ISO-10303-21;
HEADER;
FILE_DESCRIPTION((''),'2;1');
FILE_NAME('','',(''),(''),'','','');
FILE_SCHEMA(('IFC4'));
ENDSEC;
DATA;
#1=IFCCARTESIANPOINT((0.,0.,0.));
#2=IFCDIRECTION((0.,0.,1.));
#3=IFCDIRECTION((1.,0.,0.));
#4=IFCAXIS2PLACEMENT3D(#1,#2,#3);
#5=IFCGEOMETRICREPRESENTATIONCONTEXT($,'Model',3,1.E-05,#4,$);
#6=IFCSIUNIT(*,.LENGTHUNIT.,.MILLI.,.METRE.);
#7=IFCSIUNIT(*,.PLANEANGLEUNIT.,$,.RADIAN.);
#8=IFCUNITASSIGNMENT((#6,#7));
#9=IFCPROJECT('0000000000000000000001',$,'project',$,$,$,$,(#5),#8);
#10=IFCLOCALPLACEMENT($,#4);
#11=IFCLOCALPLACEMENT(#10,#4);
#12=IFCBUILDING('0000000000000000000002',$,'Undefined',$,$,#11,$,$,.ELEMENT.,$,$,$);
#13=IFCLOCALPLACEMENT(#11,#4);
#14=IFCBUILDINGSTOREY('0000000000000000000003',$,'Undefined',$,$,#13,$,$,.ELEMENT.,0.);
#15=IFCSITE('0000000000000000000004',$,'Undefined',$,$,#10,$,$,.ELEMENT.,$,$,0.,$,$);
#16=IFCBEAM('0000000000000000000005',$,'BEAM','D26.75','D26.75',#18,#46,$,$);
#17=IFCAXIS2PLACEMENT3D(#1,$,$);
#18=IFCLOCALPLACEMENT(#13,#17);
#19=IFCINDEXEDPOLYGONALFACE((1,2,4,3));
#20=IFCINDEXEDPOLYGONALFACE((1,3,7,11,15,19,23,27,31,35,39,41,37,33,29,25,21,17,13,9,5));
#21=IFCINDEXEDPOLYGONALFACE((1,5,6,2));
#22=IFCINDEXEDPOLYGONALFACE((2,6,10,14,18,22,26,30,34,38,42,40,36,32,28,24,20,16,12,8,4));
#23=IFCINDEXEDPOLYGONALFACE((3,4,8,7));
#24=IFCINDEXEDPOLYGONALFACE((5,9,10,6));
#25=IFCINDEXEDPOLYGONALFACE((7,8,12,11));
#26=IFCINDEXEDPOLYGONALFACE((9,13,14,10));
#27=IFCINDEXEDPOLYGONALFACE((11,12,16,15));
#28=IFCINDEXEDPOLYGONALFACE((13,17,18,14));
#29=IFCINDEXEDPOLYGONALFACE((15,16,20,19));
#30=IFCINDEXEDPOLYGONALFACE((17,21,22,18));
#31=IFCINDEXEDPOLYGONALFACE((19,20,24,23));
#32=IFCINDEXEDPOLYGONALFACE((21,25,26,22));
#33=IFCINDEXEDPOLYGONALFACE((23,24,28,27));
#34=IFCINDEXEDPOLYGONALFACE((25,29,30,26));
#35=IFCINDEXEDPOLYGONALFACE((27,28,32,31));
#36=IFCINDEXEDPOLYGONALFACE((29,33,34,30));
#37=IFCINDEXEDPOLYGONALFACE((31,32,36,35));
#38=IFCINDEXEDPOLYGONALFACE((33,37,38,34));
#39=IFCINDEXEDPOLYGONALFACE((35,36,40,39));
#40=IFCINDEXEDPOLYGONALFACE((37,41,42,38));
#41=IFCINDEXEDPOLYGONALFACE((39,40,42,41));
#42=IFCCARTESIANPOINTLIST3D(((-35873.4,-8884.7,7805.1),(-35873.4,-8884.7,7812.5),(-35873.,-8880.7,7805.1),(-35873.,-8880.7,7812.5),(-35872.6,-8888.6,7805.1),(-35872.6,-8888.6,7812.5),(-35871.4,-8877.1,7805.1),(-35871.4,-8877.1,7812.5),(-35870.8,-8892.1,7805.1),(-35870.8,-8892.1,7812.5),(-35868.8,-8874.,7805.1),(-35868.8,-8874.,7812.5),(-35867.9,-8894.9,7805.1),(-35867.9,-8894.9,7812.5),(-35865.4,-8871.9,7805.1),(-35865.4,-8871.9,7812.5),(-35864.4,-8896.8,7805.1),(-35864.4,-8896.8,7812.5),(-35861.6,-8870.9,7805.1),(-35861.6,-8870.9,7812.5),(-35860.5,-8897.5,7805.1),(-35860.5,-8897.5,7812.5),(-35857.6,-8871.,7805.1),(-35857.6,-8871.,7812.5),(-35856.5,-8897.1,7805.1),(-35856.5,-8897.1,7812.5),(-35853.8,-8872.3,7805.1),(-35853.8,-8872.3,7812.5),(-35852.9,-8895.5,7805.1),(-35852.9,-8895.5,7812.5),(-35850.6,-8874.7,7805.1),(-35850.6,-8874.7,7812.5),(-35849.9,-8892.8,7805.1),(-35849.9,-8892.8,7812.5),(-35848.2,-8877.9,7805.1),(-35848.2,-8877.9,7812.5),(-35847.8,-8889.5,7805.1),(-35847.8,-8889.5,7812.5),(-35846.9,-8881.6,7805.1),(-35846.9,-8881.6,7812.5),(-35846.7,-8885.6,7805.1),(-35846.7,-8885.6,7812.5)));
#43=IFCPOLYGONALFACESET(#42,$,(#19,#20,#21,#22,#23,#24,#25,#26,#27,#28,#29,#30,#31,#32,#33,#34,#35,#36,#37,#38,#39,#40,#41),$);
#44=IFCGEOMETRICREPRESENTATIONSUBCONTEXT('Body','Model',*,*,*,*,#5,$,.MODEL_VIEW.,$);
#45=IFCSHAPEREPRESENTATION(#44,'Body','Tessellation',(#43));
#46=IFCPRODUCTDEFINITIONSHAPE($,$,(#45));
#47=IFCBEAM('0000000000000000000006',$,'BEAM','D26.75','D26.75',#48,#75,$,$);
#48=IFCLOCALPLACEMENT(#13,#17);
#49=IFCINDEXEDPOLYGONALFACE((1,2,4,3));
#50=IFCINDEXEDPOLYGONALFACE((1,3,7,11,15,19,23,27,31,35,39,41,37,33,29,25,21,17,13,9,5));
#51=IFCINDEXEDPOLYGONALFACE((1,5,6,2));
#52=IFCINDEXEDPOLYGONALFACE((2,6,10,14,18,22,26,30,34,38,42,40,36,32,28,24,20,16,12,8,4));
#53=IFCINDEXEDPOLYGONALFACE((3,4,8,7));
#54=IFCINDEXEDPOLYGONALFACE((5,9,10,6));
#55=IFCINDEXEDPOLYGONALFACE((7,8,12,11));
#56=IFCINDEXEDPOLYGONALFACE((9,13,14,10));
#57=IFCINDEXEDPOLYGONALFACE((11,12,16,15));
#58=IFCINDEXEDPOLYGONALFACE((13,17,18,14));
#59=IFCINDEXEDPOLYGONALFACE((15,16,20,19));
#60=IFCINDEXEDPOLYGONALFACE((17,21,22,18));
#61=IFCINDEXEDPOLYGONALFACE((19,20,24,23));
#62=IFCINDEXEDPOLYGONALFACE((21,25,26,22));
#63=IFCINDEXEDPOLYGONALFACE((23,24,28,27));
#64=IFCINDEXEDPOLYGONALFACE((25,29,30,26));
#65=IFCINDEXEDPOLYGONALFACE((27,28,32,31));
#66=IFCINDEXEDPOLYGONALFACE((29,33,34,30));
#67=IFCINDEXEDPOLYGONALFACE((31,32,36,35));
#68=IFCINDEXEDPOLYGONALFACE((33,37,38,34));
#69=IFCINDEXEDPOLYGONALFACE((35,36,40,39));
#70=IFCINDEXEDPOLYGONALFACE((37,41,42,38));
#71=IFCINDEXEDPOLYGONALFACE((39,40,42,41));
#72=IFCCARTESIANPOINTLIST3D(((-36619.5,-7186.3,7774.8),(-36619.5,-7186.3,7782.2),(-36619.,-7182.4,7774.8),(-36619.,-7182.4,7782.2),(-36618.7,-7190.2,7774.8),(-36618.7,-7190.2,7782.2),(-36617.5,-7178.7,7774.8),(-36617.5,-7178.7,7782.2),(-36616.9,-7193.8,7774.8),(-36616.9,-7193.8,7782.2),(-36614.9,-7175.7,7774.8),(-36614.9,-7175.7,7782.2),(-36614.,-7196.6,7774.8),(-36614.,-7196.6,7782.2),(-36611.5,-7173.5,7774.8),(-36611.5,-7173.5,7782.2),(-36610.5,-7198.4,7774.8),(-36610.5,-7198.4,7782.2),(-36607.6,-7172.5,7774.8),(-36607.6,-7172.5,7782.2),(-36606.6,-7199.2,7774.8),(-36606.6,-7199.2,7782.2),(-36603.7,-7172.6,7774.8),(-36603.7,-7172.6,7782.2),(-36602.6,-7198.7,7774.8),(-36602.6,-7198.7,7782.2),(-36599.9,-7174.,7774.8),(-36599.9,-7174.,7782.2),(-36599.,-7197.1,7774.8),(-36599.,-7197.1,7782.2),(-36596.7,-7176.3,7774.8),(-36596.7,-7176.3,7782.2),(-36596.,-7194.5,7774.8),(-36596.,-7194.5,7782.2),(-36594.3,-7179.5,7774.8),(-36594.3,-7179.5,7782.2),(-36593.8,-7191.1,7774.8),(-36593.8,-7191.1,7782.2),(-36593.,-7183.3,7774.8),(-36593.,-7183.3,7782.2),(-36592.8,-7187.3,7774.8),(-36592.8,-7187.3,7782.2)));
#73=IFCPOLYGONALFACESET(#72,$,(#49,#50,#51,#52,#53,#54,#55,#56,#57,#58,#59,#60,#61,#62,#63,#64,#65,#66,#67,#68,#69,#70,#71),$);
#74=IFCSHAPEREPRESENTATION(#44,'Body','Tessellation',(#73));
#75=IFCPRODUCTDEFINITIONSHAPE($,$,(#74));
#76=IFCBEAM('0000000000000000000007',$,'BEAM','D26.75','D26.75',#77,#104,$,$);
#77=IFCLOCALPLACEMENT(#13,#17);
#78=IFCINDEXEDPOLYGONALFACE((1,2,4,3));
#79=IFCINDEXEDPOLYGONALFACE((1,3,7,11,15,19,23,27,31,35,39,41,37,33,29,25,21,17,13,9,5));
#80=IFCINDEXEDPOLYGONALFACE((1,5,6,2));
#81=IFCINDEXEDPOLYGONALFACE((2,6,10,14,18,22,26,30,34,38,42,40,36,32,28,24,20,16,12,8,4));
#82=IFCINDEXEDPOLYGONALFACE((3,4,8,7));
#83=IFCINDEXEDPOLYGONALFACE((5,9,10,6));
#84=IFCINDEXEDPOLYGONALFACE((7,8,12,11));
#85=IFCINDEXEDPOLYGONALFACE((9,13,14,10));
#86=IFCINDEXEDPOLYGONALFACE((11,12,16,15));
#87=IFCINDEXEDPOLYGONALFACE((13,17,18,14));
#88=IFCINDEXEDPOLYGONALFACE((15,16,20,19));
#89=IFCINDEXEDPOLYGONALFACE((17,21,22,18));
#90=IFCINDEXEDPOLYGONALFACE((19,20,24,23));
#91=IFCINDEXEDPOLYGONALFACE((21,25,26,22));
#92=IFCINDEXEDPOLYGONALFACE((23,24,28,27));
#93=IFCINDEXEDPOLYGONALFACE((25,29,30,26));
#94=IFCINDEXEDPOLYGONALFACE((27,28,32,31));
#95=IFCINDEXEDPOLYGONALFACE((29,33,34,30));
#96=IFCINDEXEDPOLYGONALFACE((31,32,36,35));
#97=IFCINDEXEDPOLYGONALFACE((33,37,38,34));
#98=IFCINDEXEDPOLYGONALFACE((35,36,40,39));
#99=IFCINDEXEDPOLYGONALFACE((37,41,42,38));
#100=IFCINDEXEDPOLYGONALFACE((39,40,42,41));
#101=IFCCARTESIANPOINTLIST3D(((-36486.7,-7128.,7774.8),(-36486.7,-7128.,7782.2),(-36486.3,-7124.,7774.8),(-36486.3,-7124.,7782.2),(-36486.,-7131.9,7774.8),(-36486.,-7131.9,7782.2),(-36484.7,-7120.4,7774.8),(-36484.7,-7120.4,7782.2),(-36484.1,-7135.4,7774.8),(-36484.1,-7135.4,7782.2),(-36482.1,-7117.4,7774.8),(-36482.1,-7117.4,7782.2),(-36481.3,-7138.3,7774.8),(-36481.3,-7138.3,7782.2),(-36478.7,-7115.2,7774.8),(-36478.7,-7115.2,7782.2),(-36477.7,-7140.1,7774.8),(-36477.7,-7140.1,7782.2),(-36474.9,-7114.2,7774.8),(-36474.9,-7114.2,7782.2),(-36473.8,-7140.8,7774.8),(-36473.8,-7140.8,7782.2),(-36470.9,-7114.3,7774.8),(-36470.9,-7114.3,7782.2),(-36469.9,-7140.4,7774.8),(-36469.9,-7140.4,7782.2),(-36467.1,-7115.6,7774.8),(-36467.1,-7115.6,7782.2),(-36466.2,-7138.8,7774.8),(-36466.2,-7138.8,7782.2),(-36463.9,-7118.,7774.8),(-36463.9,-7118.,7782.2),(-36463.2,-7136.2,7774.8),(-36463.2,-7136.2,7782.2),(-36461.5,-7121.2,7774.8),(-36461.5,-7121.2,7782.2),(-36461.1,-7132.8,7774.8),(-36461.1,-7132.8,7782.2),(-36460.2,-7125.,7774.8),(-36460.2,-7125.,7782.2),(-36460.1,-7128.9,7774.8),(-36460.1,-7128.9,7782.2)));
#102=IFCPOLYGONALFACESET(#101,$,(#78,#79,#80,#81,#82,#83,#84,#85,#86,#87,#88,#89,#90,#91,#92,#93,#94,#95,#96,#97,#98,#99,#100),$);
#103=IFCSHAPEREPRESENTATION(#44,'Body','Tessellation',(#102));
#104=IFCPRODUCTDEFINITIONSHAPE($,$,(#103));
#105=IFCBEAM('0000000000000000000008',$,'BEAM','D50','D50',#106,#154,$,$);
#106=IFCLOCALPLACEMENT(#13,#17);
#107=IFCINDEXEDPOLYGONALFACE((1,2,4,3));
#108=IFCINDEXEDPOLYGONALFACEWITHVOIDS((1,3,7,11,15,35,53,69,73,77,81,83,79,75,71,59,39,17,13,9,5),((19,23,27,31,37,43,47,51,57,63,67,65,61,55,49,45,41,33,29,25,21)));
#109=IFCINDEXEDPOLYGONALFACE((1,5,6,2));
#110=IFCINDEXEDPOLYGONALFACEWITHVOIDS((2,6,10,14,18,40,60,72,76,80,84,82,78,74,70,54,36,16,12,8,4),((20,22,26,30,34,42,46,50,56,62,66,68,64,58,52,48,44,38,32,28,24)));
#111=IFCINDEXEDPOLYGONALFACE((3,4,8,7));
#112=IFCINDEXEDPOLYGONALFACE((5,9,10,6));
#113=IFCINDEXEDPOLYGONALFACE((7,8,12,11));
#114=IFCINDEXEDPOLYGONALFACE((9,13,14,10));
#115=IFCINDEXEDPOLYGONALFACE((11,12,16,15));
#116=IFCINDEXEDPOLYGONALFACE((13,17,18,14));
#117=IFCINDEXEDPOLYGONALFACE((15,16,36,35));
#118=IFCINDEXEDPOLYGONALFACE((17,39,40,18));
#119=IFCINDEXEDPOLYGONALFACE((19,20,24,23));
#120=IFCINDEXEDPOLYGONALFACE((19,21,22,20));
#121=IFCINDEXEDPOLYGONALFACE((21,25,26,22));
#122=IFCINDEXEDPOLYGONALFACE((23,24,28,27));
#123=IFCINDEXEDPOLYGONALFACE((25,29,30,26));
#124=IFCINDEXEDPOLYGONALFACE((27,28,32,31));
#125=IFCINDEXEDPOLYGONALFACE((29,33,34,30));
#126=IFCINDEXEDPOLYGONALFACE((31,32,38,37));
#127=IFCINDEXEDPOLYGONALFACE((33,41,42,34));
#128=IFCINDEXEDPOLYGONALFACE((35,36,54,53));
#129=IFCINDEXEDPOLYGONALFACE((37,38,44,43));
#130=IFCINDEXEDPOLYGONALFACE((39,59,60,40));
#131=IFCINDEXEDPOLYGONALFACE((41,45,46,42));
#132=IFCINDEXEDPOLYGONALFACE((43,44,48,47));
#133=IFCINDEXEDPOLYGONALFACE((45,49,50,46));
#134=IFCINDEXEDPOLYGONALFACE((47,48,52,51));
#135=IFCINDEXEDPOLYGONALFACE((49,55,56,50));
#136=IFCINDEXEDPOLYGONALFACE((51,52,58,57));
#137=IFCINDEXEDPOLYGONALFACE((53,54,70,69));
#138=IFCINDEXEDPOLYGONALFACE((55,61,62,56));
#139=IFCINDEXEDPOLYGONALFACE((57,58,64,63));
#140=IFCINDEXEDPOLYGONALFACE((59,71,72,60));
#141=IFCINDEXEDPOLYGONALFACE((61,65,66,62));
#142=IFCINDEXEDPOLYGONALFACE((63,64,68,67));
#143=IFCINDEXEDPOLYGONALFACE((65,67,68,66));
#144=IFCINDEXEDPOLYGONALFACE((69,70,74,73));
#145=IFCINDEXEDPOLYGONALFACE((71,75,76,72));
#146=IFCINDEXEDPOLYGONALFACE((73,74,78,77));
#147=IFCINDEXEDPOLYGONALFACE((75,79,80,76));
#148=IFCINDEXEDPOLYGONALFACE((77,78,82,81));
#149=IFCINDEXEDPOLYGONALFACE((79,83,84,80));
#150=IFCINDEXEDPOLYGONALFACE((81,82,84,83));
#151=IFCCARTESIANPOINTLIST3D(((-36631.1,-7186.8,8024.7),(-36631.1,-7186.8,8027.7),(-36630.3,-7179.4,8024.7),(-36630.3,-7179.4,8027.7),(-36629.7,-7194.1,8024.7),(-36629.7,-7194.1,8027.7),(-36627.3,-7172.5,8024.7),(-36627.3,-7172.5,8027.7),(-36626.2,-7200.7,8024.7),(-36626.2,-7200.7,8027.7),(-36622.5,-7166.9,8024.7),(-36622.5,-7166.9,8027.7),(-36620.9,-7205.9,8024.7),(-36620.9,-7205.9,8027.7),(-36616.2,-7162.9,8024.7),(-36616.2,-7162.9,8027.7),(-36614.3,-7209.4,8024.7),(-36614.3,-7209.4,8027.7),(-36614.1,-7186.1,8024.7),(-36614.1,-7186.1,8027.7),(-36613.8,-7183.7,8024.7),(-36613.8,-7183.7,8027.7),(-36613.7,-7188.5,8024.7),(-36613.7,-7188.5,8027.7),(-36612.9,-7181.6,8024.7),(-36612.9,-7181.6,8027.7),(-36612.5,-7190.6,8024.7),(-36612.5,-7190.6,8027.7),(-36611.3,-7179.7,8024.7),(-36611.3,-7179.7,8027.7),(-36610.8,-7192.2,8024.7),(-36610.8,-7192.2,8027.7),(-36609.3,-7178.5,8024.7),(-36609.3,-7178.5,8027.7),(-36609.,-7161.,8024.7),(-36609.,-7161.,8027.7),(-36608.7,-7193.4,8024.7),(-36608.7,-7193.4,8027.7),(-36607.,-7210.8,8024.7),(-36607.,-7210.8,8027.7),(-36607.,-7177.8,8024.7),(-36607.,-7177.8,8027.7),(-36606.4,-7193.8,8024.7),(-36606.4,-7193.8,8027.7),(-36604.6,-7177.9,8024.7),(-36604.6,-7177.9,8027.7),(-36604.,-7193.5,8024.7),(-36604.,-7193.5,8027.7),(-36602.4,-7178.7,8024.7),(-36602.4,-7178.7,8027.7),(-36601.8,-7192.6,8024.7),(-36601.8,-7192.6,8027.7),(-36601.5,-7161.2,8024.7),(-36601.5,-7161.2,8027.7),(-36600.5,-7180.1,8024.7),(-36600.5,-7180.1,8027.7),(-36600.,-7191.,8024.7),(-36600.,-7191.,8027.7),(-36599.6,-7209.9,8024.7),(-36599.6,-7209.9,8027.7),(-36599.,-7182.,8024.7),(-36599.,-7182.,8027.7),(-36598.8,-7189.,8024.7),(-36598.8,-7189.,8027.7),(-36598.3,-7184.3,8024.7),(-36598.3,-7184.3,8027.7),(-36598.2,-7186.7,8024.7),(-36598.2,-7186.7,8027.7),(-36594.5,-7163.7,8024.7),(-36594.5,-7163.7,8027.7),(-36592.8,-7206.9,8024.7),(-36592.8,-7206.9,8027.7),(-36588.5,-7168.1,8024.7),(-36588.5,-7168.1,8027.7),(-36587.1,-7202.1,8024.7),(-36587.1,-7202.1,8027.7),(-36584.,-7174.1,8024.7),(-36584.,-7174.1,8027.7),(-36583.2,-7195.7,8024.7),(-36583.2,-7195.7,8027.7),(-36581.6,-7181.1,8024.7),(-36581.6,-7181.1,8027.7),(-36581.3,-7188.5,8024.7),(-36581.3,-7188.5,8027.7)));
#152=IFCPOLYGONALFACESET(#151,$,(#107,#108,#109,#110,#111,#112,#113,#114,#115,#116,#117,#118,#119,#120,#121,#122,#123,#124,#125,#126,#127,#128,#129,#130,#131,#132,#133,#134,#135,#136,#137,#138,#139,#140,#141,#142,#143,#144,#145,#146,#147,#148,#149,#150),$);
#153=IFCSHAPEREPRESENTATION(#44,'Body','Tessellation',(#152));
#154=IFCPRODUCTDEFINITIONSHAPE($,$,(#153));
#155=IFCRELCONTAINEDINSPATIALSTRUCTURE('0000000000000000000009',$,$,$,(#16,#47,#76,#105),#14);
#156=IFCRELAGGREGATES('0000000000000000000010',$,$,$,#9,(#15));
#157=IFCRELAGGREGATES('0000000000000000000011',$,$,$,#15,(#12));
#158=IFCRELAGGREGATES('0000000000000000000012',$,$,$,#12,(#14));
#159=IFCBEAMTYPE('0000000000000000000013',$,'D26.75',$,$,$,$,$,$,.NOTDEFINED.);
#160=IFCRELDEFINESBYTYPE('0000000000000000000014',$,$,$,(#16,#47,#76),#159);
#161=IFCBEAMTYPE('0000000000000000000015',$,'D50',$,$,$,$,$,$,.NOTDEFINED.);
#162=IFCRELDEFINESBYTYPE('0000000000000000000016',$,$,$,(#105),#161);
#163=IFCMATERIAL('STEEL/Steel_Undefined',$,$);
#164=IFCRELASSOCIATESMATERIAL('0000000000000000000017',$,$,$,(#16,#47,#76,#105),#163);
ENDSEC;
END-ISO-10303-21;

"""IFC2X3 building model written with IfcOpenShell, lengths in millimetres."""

from ifc_helpers import new_model, si_unit, frame, origin_with_axes, origin_2d_with_axis, place, context, subcontext, project, spatial, circle, extrude, material, type_object, element, save


model = new_model("IFC2X3")

# Units and contexts
model_context = context("Model", 3, precision=1e-05, world=origin_with_axes())
body_context = subcontext(model_context, "Body", "Model", "MODEL_VIEW")
ifc_project = project(units=[si_unit("LENGTHUNIT", "METRE", prefix="MILLI"), si_unit("PLANEANGLEUNIT", "RADIAN")], contexts=[model_context])

# Site, building, storey
site_placement = place(None, origin_with_axes())
site = spatial("IfcSite", under=ifc_project, at=site_placement, Name="Undefined", CompositionType="ELEMENT", RefElevation=0.0)
building_placement = place(site_placement, origin_with_axes())
building = spatial("IfcBuilding", under=site, at=building_placement, Name="Undefined", CompositionType="ELEMENT")
storey_placement = place(building_placement, origin_with_axes())
storey = spatial("IfcBuildingStorey", under=building, at=storey_placement, Name="Undefined", CompositionType="ELEMENT", Elevation=0.0)

# Shared definitions
ifc_material = material(Name="STEEL/Steel_Undefined")
beam_type_1 = type_object("IfcBeamType", Name="D26.75", PredefinedType="NOTDEFINED")

# Beam
beam_1_placement = place(storey_placement, frame((-35860.0, -8884.1, 7812.5), z_axis=(-0.915553, -0.402198, 0.0), x_axis=(0.0, 0.0, -1.0)))
element("IfcBeam", 1, at=beam_1_placement, inside=storey, type_object=beam_type_1, material=ifc_material, Name="BEAM", Description="D26.75", ObjectType="D26.75", context=body_context, shape_type="SweptSolid", body=[
    extrude(circle(Radius=13.4, at=origin_2d_with_axis()), frame((7.4, 0.0, 0.0), z_axis=(-1.0, 0.0, 0.0), x_axis=(0.0, -1.0, 0.0)), (0.0, 0.0, 1.0), 7.4),
])

# Beams
for number, where, z_axis, x_axis, name in (
    (2, (-36606.1, -7185.8, 7782.2), (-0.915553, -0.402198, 0.0), (0.0, 0.0, -1.0), "BEAM"),
    (3, (-36473.4, -7127.5, 7782.2), (-0.915553, -0.402198, 0.0), (0.0, 0.0, -1.0), "BEAM"),
):
    element("IfcBeam", number, at=place(storey_placement, frame(where, z_axis=z_axis, x_axis=x_axis)), inside=storey, type_object=beam_type_1, material=ifc_material, Name=name, Description="D26.75", ObjectType="D26.75", context=body_context, shape_type="SweptSolid", body=[
        extrude(circle(Radius=13.4, at=origin_2d_with_axis()), frame((7.4, 0.0, 0.0), z_axis=(-1.0, 0.0, 0.0), x_axis=(0.0, -1.0, 0.0)), (0.0, 0.0, 1.0), 7.4),
    ])

# Beam, opening
beam_type_2 = type_object("IfcBeamType", Name="D50", PredefinedType="NOTDEFINED")
beam_2_placement = place(storey_placement, frame((-36606.1, -7185.8, 8027.7), z_axis=(-0.915553, -0.402198, 0.0), x_axis=(0.0, 0.0, -1.0)))
beam_2 = element("IfcBeam", 4, at=beam_2_placement, inside=storey, type_object=beam_type_2, material=ifc_material, Name="BEAM", Description="D50", ObjectType="D50", context=body_context, shape_type="SweptSolid", body=[
    extrude(circle(Radius=25.0, at=origin_2d_with_axis()), frame((3.0, 0.0, 0.0), z_axis=(-1.0, 0.0, 0.0), x_axis=(0.0, -1.0, 0.0)), (0.0, 0.0, 1.0), 3.0),
])
opening_1_placement = place(storey_placement, frame((-36606.1, -7185.8, 8027.7), z_axis=(-0.915553, -0.402198, 0.0), x_axis=(0.0, 0.0, -1.0)))
element("IfcOpeningElement", 5, at=opening_1_placement, cuts=beam_2, ObjectType="Recess", context=body_context, shape_type="SweptSolid", body=[
    extrude(circle(Radius=8.0, at=origin_2d_with_axis()), frame((245.5, 0.0, 0.0), z_axis=(-1.0, 0.0, 0.0), x_axis=(0.0, -1.0, 0.0)), (0.0, 0.0, 1.0), 292.6),
])

save(model, "model.ifc")
